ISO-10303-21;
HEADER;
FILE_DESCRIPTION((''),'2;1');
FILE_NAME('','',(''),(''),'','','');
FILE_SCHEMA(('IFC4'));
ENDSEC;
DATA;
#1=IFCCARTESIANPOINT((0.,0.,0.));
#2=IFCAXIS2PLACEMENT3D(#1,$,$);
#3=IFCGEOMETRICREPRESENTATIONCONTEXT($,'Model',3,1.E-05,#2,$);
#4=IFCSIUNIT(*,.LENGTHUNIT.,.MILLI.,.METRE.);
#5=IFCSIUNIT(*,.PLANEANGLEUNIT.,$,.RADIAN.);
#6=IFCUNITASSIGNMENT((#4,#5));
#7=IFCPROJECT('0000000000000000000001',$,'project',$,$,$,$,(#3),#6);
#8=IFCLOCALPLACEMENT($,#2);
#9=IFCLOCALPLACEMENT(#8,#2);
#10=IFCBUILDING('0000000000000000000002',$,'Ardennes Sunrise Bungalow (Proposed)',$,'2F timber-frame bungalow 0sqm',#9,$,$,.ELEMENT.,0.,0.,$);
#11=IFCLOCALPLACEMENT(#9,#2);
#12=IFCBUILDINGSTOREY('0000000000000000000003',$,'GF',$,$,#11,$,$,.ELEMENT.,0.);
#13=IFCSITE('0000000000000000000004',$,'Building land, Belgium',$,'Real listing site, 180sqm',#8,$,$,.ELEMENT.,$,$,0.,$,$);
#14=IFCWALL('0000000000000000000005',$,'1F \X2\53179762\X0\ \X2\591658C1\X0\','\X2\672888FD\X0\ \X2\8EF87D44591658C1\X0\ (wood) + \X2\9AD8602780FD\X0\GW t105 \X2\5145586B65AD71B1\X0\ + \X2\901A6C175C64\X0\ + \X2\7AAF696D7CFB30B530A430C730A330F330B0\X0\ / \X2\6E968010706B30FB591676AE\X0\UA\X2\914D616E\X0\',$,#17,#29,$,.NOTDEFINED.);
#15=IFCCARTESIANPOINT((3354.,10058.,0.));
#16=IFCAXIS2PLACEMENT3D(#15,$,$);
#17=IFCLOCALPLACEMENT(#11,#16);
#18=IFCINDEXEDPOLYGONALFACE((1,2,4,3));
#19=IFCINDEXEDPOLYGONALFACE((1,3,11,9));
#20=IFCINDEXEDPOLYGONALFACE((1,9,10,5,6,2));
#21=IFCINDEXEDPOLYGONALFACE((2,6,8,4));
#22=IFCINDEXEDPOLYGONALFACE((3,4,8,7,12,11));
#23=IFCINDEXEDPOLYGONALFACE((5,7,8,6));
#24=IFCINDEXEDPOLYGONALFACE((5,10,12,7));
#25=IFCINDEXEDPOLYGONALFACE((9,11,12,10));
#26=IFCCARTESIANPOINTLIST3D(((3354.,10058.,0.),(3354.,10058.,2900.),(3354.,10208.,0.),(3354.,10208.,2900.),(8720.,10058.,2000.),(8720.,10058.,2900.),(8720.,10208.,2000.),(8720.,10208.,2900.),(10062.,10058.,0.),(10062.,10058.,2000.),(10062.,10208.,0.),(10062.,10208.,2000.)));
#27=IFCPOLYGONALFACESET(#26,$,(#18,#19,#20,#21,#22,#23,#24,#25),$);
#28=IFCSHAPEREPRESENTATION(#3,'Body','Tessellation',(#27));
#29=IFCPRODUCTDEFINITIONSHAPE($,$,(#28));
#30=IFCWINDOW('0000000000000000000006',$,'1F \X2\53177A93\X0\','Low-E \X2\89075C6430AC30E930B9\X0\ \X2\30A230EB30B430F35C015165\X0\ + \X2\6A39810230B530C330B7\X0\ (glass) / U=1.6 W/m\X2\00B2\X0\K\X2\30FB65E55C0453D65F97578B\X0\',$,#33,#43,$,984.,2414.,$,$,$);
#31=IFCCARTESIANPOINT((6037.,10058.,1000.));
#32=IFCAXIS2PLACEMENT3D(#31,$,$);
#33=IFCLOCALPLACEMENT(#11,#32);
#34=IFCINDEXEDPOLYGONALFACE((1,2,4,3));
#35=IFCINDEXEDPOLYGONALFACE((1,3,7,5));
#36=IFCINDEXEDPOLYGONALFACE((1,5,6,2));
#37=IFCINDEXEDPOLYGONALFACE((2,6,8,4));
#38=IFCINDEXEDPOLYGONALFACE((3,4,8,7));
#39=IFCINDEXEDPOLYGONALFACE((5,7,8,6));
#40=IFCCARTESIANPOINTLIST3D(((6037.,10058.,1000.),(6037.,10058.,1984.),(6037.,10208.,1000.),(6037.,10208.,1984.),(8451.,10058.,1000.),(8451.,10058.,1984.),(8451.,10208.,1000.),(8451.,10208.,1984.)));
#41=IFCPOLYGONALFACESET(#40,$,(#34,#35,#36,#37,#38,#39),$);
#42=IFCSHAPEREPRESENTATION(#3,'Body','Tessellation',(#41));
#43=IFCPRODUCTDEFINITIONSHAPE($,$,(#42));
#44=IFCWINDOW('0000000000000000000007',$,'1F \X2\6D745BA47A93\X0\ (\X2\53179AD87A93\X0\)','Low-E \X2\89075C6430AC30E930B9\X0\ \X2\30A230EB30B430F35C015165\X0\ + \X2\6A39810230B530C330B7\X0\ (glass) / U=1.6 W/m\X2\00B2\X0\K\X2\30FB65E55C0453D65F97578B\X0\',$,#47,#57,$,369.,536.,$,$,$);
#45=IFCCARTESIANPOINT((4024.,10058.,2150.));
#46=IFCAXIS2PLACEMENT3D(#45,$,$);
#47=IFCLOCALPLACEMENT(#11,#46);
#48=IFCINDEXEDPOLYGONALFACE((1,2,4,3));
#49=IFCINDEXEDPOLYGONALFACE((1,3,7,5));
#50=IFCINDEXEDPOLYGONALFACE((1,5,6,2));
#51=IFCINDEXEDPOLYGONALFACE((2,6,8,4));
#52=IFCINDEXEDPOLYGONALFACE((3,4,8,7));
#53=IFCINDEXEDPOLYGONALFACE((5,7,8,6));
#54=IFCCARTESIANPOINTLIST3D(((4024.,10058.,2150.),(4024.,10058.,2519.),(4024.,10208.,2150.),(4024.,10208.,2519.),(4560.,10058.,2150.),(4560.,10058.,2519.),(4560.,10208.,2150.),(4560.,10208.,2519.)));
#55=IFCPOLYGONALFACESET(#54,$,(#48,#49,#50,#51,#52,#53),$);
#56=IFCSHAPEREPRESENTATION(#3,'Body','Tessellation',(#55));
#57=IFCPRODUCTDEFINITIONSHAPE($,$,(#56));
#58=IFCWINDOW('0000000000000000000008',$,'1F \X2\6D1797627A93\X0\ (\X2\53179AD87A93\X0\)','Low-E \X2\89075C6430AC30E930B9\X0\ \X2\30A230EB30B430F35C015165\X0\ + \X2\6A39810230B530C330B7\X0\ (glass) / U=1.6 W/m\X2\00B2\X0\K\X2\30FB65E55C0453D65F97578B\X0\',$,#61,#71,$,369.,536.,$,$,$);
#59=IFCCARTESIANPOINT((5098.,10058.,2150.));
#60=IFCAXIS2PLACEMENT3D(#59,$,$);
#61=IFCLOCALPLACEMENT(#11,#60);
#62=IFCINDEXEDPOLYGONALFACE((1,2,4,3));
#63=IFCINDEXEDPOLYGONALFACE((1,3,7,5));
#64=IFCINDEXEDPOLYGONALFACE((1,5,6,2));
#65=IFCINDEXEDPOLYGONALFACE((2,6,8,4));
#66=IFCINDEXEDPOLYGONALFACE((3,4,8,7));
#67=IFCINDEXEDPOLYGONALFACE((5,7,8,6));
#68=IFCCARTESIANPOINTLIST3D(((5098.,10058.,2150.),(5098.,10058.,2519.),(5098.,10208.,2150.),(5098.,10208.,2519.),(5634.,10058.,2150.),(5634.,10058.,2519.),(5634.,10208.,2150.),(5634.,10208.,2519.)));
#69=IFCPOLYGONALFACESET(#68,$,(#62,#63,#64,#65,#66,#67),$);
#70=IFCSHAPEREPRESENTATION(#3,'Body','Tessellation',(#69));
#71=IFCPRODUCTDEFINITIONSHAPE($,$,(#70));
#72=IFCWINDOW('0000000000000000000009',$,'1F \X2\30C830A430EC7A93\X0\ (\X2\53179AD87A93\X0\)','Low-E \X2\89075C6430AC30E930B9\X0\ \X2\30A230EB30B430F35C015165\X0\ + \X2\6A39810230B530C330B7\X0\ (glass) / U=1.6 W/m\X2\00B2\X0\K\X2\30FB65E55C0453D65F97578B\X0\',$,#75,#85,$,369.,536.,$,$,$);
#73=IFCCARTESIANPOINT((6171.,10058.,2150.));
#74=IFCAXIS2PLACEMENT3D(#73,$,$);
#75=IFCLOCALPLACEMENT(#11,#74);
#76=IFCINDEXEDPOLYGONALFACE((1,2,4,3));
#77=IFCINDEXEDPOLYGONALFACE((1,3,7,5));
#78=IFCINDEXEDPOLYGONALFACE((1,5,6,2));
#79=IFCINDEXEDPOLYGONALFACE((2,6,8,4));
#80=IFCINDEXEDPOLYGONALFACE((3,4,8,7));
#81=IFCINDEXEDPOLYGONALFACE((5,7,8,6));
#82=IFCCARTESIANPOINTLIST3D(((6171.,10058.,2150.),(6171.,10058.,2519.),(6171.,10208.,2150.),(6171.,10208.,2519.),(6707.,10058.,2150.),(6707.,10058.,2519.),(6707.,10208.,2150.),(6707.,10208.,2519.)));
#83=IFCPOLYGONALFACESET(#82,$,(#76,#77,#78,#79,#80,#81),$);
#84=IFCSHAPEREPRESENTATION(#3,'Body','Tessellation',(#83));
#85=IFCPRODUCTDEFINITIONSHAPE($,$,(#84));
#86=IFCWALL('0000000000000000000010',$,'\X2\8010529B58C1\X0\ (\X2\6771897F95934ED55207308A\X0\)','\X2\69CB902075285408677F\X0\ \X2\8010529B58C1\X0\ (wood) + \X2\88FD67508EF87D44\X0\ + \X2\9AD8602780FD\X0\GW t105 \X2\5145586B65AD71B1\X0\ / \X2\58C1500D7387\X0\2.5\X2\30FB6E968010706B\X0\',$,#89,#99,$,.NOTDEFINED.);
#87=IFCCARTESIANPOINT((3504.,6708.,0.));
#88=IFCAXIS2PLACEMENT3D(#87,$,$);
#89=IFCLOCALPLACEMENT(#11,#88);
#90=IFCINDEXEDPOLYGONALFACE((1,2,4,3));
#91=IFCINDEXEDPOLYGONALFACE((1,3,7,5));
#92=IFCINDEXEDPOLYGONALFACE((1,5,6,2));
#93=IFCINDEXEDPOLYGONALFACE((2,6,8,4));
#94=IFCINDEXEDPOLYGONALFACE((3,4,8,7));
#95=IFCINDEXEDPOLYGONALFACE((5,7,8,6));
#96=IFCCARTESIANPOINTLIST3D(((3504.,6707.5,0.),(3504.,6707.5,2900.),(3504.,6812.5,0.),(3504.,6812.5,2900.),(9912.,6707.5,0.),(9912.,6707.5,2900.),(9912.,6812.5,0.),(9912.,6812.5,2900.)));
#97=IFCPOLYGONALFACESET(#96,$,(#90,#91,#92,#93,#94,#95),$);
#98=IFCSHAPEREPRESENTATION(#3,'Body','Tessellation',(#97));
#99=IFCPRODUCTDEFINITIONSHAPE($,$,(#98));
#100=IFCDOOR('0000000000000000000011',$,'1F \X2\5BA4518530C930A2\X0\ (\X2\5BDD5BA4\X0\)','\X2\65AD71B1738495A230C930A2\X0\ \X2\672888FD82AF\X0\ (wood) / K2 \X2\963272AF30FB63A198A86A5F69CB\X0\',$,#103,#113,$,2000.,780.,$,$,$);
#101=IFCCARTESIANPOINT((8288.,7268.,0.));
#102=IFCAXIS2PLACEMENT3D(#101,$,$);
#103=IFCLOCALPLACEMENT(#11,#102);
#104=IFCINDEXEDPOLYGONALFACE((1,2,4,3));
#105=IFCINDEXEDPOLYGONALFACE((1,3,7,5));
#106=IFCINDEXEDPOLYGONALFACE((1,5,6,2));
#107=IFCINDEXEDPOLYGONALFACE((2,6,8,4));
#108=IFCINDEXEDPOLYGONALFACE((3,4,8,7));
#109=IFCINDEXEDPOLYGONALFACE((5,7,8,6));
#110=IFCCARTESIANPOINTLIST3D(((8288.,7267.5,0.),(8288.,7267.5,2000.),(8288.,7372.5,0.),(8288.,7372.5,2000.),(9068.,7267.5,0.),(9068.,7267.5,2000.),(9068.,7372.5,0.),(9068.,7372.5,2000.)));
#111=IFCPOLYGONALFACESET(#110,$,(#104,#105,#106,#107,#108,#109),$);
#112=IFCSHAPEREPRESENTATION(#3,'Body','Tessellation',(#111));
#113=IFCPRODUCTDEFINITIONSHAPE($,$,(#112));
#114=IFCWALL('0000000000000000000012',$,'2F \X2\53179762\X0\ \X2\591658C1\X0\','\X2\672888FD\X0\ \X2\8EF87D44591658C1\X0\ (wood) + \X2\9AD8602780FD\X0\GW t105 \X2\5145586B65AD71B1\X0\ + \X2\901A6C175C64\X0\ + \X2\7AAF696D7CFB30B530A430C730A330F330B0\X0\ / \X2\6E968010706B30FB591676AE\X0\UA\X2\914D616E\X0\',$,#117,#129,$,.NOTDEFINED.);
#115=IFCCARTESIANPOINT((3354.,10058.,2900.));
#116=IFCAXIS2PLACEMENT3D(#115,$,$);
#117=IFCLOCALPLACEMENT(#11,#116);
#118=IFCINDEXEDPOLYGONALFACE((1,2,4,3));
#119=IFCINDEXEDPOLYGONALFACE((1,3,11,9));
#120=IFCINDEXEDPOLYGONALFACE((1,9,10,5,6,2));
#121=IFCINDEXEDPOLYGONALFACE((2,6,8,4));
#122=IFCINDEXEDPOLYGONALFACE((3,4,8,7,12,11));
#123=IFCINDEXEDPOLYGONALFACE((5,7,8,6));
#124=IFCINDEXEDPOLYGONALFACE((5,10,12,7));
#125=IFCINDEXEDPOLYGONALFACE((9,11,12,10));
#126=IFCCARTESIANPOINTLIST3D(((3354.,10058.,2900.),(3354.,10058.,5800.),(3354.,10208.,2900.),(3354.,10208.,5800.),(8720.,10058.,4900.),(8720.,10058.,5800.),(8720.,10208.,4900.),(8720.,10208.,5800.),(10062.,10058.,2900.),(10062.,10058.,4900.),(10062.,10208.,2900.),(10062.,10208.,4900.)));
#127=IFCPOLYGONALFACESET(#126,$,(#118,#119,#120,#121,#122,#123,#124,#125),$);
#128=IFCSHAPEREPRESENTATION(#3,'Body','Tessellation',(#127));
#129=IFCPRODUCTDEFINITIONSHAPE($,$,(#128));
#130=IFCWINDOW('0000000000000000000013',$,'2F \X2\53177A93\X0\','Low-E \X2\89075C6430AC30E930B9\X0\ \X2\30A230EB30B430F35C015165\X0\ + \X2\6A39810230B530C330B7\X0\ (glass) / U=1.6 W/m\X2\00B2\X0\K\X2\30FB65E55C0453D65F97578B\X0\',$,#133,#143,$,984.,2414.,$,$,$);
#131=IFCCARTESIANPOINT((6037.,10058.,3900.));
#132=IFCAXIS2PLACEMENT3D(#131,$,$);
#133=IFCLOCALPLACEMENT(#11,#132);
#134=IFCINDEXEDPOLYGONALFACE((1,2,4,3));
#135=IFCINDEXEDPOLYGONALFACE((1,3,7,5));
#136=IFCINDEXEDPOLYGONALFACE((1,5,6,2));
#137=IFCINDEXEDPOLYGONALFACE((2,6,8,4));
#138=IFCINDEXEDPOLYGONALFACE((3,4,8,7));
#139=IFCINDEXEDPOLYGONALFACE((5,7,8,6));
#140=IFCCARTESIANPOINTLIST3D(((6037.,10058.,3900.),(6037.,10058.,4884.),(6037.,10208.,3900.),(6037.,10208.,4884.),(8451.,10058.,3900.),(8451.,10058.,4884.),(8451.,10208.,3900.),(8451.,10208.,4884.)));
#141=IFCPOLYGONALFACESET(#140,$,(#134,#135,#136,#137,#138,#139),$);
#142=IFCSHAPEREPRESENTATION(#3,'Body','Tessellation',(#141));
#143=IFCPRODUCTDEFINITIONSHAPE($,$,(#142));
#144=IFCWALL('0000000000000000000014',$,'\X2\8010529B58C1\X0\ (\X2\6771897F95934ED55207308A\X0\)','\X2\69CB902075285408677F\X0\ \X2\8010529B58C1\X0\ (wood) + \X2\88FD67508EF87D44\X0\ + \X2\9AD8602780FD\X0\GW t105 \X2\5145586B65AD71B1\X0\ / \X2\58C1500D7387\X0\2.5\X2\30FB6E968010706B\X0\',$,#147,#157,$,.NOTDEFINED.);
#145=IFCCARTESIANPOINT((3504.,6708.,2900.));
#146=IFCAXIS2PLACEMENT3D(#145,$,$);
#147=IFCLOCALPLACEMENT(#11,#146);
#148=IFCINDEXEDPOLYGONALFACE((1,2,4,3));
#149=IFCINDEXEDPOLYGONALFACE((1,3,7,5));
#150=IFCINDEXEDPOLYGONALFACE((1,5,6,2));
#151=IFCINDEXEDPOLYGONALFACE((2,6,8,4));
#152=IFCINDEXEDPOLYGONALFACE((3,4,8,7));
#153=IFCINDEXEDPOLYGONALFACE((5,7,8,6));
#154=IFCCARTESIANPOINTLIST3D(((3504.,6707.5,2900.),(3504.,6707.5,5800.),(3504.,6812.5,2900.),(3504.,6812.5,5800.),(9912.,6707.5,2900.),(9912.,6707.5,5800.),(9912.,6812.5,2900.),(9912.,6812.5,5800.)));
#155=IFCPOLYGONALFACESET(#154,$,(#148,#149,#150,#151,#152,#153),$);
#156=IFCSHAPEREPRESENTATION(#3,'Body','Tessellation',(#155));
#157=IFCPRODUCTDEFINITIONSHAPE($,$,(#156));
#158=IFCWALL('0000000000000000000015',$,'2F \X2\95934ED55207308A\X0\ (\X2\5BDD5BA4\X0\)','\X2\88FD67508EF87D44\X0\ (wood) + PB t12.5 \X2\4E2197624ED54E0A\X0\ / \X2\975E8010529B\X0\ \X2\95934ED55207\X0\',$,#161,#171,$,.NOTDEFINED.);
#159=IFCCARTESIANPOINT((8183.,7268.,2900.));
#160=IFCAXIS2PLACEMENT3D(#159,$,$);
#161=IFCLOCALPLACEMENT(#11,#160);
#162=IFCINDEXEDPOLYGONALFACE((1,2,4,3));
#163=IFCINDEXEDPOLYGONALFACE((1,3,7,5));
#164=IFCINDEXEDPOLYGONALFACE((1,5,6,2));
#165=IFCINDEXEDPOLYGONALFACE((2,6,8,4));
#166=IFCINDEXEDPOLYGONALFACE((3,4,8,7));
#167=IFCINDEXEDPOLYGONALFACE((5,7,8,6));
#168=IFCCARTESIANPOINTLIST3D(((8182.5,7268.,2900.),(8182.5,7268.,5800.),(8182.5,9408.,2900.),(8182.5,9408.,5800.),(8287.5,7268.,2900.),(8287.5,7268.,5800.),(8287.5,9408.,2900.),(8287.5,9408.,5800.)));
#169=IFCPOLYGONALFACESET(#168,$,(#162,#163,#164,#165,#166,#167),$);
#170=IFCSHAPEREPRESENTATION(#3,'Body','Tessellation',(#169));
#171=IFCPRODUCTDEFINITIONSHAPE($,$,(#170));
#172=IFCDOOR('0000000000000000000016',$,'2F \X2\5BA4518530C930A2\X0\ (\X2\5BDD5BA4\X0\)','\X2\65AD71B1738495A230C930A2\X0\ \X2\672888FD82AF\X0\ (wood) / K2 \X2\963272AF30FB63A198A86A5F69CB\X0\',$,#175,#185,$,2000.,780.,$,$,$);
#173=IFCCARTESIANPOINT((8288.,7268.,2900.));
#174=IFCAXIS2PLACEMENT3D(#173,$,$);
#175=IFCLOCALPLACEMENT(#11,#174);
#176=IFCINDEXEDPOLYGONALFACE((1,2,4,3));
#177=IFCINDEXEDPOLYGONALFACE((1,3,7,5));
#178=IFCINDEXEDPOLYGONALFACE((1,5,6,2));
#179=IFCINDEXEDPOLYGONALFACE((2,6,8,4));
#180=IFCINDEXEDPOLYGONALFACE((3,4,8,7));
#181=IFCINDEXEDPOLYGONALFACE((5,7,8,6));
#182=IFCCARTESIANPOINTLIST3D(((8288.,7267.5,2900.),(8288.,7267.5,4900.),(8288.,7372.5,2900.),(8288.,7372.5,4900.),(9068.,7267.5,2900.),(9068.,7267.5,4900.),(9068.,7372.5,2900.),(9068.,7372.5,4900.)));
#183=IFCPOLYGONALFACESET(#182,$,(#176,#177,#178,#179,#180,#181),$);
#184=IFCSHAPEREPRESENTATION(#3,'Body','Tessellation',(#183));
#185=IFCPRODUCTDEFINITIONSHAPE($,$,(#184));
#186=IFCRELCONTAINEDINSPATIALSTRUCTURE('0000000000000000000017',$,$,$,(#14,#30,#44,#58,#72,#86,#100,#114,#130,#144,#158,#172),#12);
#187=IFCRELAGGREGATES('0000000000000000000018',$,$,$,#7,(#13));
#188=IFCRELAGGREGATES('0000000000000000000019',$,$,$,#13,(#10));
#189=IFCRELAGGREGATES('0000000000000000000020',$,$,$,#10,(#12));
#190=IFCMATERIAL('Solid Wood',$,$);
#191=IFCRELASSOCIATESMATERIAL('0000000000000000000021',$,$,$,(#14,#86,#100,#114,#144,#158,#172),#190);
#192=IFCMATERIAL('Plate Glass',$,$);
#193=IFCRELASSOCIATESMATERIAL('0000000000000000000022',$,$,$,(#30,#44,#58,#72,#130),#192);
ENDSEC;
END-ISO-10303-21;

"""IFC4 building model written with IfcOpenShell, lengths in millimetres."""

from ifc_helpers import new_model, si_unit, frame, frame_2d, origin, place, context, project, spatial, rectangle, extrude, material, element, fill, save


model = new_model("IFC4")

# Units and contexts
model_context = context("Model", 3, precision=1e-05, world=origin())
ifc_project = project(units=[si_unit("LENGTHUNIT", "METRE", prefix="MILLI"), si_unit("PLANEANGLEUNIT", "RADIAN")], contexts=[model_context])

# Site, building, storey
site_placement = place(None, origin())
site = spatial("IfcSite", under=ifc_project, at=site_placement, Name="Building land, Belgium", ObjectType="Real listing site, 180sqm", CompositionType="ELEMENT", RefElevation=0.0)
building_placement = place(site_placement, origin())
building = spatial("IfcBuilding", under=site, at=building_placement, Name="Ardennes Sunrise Bungalow (Proposed)", ObjectType="2F timber-frame bungalow 0sqm", CompositionType="ELEMENT", ElevationOfRefHeight=0.0, ElevationOfTerrain=0.0)
storey_placement = place(building_placement, origin())
storey = spatial("IfcBuildingStorey", under=building, at=storey_placement, Name="GF", CompositionType="ELEMENT", Elevation=0.0)

# Wall, openings, windows
ifc_material_1 = material(Name="Solid Wood")
wall_1_placement = place(storey_placement, frame((3354.0, 10058.0, 0.0)))
wall_1 = element("IfcWall", 1, at=wall_1_placement, inside=storey, material=ifc_material_1, Name="1F 北面 外壁", Description="木製 軸組外壁 (wood) + 高性能GW t105 充填断熱 + 通気層 + 窯業系サイディング / 準耐火・外皮UA配慮", PredefinedType="NOTDEFINED", context=model_context, shape_type="SweptSolid", body=[
    extrude(rectangle(XDim=6708.0, YDim=150.0, at=frame_2d((3354.0, 75.0))), frame((3354.0, 10058.0, 0.0)), (0.0, 0.0, 1.0), 2900.0),
])
opening_1_placement = place(storey_placement, frame((6037.0, 10058.0, 1000.0)))
opening_1 = element("IfcOpeningElement", 2, at=opening_1_placement, cuts=wall_1, PredefinedType="NOTDEFINED", context=model_context, shape_type="SweptSolid", body=[
    extrude(rectangle(XDim=2414.0, YDim=150.0, at=frame_2d((1207.0, 75.0))), frame((6037.0, 10058.0, 1000.0)), (0.0, 0.0, 1.0), 984.0),
])
opening_2_placement = place(storey_placement, frame((4024.0, 10058.0, 2150.0)))
opening_2 = element("IfcOpeningElement", 3, at=opening_2_placement, cuts=wall_1, PredefinedType="NOTDEFINED", context=model_context, shape_type="SweptSolid", body=[
    extrude(rectangle(XDim=536.0, YDim=150.0, at=frame_2d((268.0, 75.0))), frame((4024.0, 10058.0, 2150.0)), (0.0, 0.0, 1.0), 369.0),
])
opening_3_placement = place(storey_placement, frame((5098.0, 10058.0, 2150.0)))
opening_3 = element("IfcOpeningElement", 4, at=opening_3_placement, cuts=wall_1, PredefinedType="NOTDEFINED", context=model_context, shape_type="SweptSolid", body=[
    extrude(rectangle(XDim=536.0, YDim=150.0, at=frame_2d((268.0, 75.0))), frame((5098.0, 10058.0, 2150.0)), (0.0, 0.0, 1.0), 369.0),
])
opening_4_placement = place(storey_placement, frame((6171.0, 10058.0, 2150.0)))
opening_4 = element("IfcOpeningElement", 5, at=opening_4_placement, cuts=wall_1, PredefinedType="NOTDEFINED", context=model_context, shape_type="SweptSolid", body=[
    extrude(rectangle(XDim=536.0, YDim=150.0, at=frame_2d((268.0, 75.0))), frame((6171.0, 10058.0, 2150.0)), (0.0, 0.0, 1.0), 369.0),
])
ifc_material_2 = material(Name="Plate Glass")
window_1_placement = place(storey_placement, frame((6037.0, 10058.0, 1000.0)))
window_1 = element("IfcWindow", 6, at=window_1_placement, inside=storey, material=ifc_material_2, Name="1F 北窓", Description="Low-E 複層ガラス アルゴン封入 + 樹脂サッシ (glass) / U=1.6 W/m²K・日射取得型", OverallHeight=984.0, OverallWidth=2414.0, context=model_context, shape_type="SweptSolid", body=[
    extrude(rectangle(XDim=2414.0, YDim=150.0, at=frame_2d((1207.0, 75.0))), frame((6037.0, 10058.0, 1000.0)), (0.0, 0.0, 1.0), 984.0),
])
fill(opening_1, window_1)
window_2_placement = place(storey_placement, frame((4024.0, 10058.0, 2150.0)))
window_2 = element("IfcWindow", 7, at=window_2_placement, inside=storey, material=ifc_material_2, Name="1F 浴室窓 (北高窓)", Description="Low-E 複層ガラス アルゴン封入 + 樹脂サッシ (glass) / U=1.6 W/m²K・日射取得型", OverallHeight=369.0, OverallWidth=536.0, context=model_context, shape_type="SweptSolid", body=[
    extrude(rectangle(XDim=536.0, YDim=150.0, at=frame_2d((268.0, 75.0))), frame((4024.0, 10058.0, 2150.0)), (0.0, 0.0, 1.0), 369.0),
])
fill(opening_2, window_2)
window_3_placement = place(storey_placement, frame((5098.0, 10058.0, 2150.0)))
window_3 = element("IfcWindow", 8, at=window_3_placement, inside=storey, material=ifc_material_2, Name="1F 洗面窓 (北高窓)", Description="Low-E 複層ガラス アルゴン封入 + 樹脂サッシ (glass) / U=1.6 W/m²K・日射取得型", OverallHeight=369.0, OverallWidth=536.0, context=model_context, shape_type="SweptSolid", body=[
    extrude(rectangle(XDim=536.0, YDim=150.0, at=frame_2d((268.0, 75.0))), frame((5098.0, 10058.0, 2150.0)), (0.0, 0.0, 1.0), 369.0),
])
fill(opening_3, window_3)
window_4_placement = place(storey_placement, frame((6171.0, 10058.0, 2150.0)))
window_4 = element("IfcWindow", 9, at=window_4_placement, inside=storey, material=ifc_material_2, Name="1F トイレ窓 (北高窓)", Description="Low-E 複層ガラス アルゴン封入 + 樹脂サッシ (glass) / U=1.6 W/m²K・日射取得型", OverallHeight=369.0, OverallWidth=536.0, context=model_context, shape_type="SweptSolid", body=[
    extrude(rectangle(XDim=536.0, YDim=150.0, at=frame_2d((268.0, 75.0))), frame((6171.0, 10058.0, 2150.0)), (0.0, 0.0, 1.0), 369.0),
])
fill(opening_4, window_4)

# Wall
wall_2_placement = place(storey_placement, frame((3504.0, 6708.0, 0.0)))
element("IfcWall", 10, at=wall_2_placement, inside=storey, material=ifc_material_1, Name="耐力壁 (東西間仕切り)", Description="構造用合板 耐力壁 (wood) + 製材軸組 + 高性能GW t105 充填断熱 / 壁倍率2.5・準耐火", PredefinedType="NOTDEFINED", context=model_context, shape_type="SweptSolid", body=[
    extrude(rectangle(XDim=6408.0, YDim=105.0, at=frame_2d((3204.0, 52.0))), frame((3504.0, 6708.0, 0.0)), (0.0, 0.0, 1.0), 2900.0),
])

# Door
door_1_placement = place(storey_placement, frame((8288.0, 7268.0, 0.0)))
element("IfcDoor", 11, at=door_1_placement, inside=storey, material=ifc_material_1, Name="1F 室内ドア (寝室)", Description="断熱玄関ドア 木製芯 (wood) / K2 防犯・採風機構", OverallHeight=2000.0, OverallWidth=780.0, context=model_context, shape_type="SweptSolid", body=[
    extrude(rectangle(XDim=780.0, YDim=105.0, at=frame_2d((390.0, 52.0))), frame((8288.0, 7268.0, 0.0)), (0.0, 0.0, 1.0), 2000.0),
])

# Wall, opening, window
wall_3_placement = place(storey_placement, frame((3354.0, 10058.0, 2900.0)))
wall_3 = element("IfcWall", 12, at=wall_3_placement, inside=storey, material=ifc_material_1, Name="2F 北面 外壁", Description="木製 軸組外壁 (wood) + 高性能GW t105 充填断熱 + 通気層 + 窯業系サイディング / 準耐火・外皮UA配慮", PredefinedType="NOTDEFINED", context=model_context, shape_type="SweptSolid", body=[
    extrude(rectangle(XDim=6708.0, YDim=150.0, at=frame_2d((3354.0, 75.0))), frame((3354.0, 10058.0, 2900.0)), (0.0, 0.0, 1.0), 2900.0),
])
opening_5_placement = place(storey_placement, frame((6037.0, 10058.0, 3900.0)))
opening_5 = element("IfcOpeningElement", 13, at=opening_5_placement, cuts=wall_3, PredefinedType="NOTDEFINED", context=model_context, shape_type="SweptSolid", body=[
    extrude(rectangle(XDim=2414.0, YDim=150.0, at=frame_2d((1207.0, 75.0))), frame((6037.0, 10058.0, 3900.0)), (0.0, 0.0, 1.0), 984.0),
])
window_5_placement = place(storey_placement, frame((6037.0, 10058.0, 3900.0)))
window_5 = element("IfcWindow", 14, at=window_5_placement, inside=storey, material=ifc_material_2, Name="2F 北窓", Description="Low-E 複層ガラス アルゴン封入 + 樹脂サッシ (glass) / U=1.6 W/m²K・日射取得型", OverallHeight=984.0, OverallWidth=2414.0, context=model_context, shape_type="SweptSolid", body=[
    extrude(rectangle(XDim=2414.0, YDim=150.0, at=frame_2d((1207.0, 75.0))), frame((6037.0, 10058.0, 3900.0)), (0.0, 0.0, 1.0), 984.0),
])
fill(opening_5, window_5)

# Walls
wall_4_placement = place(storey_placement, frame((3504.0, 6708.0, 2900.0)))
element("IfcWall", 15, at=wall_4_placement, inside=storey, material=ifc_material_1, Name="耐力壁 (東西間仕切り)", Description="構造用合板 耐力壁 (wood) + 製材軸組 + 高性能GW t105 充填断熱 / 壁倍率2.5・準耐火", PredefinedType="NOTDEFINED", context=model_context, shape_type="SweptSolid", body=[
    extrude(rectangle(XDim=6408.0, YDim=105.0, at=frame_2d((3204.0, 52.0))), frame((3504.0, 6708.0, 2900.0)), (0.0, 0.0, 1.0), 2900.0),
])
wall_5_placement = place(storey_placement, frame((8183.0, 7268.0, 2900.0)))
element("IfcWall", 16, at=wall_5_placement, inside=storey, material=ifc_material_1, Name="2F 間仕切り (寝室)", Description="製材軸組 (wood) + PB t12.5 両面仕上 / 非耐力 間仕切", PredefinedType="NOTDEFINED", context=model_context, shape_type="SweptSolid", body=[
    extrude(rectangle(XDim=105.0, YDim=2140.0, at=frame_2d((52.0, 1070.0))), frame((8183.0, 7268.0, 2900.0)), (0.0, 0.0, 1.0), 2900.0),
])

# Door
door_2_placement = place(storey_placement, frame((8288.0, 7268.0, 2900.0)))
element("IfcDoor", 17, at=door_2_placement, inside=storey, material=ifc_material_1, Name="2F 室内ドア (寝室)", Description="断熱玄関ドア 木製芯 (wood) / K2 防犯・採風機構", OverallHeight=2000.0, OverallWidth=780.0, context=model_context, shape_type="SweptSolid", body=[
    extrude(rectangle(XDim=780.0, YDim=105.0, at=frame_2d((390.0, 52.0))), frame((8288.0, 7268.0, 2900.0)), (0.0, 0.0, 1.0), 2000.0),
])

save(model, "model.ifc")
